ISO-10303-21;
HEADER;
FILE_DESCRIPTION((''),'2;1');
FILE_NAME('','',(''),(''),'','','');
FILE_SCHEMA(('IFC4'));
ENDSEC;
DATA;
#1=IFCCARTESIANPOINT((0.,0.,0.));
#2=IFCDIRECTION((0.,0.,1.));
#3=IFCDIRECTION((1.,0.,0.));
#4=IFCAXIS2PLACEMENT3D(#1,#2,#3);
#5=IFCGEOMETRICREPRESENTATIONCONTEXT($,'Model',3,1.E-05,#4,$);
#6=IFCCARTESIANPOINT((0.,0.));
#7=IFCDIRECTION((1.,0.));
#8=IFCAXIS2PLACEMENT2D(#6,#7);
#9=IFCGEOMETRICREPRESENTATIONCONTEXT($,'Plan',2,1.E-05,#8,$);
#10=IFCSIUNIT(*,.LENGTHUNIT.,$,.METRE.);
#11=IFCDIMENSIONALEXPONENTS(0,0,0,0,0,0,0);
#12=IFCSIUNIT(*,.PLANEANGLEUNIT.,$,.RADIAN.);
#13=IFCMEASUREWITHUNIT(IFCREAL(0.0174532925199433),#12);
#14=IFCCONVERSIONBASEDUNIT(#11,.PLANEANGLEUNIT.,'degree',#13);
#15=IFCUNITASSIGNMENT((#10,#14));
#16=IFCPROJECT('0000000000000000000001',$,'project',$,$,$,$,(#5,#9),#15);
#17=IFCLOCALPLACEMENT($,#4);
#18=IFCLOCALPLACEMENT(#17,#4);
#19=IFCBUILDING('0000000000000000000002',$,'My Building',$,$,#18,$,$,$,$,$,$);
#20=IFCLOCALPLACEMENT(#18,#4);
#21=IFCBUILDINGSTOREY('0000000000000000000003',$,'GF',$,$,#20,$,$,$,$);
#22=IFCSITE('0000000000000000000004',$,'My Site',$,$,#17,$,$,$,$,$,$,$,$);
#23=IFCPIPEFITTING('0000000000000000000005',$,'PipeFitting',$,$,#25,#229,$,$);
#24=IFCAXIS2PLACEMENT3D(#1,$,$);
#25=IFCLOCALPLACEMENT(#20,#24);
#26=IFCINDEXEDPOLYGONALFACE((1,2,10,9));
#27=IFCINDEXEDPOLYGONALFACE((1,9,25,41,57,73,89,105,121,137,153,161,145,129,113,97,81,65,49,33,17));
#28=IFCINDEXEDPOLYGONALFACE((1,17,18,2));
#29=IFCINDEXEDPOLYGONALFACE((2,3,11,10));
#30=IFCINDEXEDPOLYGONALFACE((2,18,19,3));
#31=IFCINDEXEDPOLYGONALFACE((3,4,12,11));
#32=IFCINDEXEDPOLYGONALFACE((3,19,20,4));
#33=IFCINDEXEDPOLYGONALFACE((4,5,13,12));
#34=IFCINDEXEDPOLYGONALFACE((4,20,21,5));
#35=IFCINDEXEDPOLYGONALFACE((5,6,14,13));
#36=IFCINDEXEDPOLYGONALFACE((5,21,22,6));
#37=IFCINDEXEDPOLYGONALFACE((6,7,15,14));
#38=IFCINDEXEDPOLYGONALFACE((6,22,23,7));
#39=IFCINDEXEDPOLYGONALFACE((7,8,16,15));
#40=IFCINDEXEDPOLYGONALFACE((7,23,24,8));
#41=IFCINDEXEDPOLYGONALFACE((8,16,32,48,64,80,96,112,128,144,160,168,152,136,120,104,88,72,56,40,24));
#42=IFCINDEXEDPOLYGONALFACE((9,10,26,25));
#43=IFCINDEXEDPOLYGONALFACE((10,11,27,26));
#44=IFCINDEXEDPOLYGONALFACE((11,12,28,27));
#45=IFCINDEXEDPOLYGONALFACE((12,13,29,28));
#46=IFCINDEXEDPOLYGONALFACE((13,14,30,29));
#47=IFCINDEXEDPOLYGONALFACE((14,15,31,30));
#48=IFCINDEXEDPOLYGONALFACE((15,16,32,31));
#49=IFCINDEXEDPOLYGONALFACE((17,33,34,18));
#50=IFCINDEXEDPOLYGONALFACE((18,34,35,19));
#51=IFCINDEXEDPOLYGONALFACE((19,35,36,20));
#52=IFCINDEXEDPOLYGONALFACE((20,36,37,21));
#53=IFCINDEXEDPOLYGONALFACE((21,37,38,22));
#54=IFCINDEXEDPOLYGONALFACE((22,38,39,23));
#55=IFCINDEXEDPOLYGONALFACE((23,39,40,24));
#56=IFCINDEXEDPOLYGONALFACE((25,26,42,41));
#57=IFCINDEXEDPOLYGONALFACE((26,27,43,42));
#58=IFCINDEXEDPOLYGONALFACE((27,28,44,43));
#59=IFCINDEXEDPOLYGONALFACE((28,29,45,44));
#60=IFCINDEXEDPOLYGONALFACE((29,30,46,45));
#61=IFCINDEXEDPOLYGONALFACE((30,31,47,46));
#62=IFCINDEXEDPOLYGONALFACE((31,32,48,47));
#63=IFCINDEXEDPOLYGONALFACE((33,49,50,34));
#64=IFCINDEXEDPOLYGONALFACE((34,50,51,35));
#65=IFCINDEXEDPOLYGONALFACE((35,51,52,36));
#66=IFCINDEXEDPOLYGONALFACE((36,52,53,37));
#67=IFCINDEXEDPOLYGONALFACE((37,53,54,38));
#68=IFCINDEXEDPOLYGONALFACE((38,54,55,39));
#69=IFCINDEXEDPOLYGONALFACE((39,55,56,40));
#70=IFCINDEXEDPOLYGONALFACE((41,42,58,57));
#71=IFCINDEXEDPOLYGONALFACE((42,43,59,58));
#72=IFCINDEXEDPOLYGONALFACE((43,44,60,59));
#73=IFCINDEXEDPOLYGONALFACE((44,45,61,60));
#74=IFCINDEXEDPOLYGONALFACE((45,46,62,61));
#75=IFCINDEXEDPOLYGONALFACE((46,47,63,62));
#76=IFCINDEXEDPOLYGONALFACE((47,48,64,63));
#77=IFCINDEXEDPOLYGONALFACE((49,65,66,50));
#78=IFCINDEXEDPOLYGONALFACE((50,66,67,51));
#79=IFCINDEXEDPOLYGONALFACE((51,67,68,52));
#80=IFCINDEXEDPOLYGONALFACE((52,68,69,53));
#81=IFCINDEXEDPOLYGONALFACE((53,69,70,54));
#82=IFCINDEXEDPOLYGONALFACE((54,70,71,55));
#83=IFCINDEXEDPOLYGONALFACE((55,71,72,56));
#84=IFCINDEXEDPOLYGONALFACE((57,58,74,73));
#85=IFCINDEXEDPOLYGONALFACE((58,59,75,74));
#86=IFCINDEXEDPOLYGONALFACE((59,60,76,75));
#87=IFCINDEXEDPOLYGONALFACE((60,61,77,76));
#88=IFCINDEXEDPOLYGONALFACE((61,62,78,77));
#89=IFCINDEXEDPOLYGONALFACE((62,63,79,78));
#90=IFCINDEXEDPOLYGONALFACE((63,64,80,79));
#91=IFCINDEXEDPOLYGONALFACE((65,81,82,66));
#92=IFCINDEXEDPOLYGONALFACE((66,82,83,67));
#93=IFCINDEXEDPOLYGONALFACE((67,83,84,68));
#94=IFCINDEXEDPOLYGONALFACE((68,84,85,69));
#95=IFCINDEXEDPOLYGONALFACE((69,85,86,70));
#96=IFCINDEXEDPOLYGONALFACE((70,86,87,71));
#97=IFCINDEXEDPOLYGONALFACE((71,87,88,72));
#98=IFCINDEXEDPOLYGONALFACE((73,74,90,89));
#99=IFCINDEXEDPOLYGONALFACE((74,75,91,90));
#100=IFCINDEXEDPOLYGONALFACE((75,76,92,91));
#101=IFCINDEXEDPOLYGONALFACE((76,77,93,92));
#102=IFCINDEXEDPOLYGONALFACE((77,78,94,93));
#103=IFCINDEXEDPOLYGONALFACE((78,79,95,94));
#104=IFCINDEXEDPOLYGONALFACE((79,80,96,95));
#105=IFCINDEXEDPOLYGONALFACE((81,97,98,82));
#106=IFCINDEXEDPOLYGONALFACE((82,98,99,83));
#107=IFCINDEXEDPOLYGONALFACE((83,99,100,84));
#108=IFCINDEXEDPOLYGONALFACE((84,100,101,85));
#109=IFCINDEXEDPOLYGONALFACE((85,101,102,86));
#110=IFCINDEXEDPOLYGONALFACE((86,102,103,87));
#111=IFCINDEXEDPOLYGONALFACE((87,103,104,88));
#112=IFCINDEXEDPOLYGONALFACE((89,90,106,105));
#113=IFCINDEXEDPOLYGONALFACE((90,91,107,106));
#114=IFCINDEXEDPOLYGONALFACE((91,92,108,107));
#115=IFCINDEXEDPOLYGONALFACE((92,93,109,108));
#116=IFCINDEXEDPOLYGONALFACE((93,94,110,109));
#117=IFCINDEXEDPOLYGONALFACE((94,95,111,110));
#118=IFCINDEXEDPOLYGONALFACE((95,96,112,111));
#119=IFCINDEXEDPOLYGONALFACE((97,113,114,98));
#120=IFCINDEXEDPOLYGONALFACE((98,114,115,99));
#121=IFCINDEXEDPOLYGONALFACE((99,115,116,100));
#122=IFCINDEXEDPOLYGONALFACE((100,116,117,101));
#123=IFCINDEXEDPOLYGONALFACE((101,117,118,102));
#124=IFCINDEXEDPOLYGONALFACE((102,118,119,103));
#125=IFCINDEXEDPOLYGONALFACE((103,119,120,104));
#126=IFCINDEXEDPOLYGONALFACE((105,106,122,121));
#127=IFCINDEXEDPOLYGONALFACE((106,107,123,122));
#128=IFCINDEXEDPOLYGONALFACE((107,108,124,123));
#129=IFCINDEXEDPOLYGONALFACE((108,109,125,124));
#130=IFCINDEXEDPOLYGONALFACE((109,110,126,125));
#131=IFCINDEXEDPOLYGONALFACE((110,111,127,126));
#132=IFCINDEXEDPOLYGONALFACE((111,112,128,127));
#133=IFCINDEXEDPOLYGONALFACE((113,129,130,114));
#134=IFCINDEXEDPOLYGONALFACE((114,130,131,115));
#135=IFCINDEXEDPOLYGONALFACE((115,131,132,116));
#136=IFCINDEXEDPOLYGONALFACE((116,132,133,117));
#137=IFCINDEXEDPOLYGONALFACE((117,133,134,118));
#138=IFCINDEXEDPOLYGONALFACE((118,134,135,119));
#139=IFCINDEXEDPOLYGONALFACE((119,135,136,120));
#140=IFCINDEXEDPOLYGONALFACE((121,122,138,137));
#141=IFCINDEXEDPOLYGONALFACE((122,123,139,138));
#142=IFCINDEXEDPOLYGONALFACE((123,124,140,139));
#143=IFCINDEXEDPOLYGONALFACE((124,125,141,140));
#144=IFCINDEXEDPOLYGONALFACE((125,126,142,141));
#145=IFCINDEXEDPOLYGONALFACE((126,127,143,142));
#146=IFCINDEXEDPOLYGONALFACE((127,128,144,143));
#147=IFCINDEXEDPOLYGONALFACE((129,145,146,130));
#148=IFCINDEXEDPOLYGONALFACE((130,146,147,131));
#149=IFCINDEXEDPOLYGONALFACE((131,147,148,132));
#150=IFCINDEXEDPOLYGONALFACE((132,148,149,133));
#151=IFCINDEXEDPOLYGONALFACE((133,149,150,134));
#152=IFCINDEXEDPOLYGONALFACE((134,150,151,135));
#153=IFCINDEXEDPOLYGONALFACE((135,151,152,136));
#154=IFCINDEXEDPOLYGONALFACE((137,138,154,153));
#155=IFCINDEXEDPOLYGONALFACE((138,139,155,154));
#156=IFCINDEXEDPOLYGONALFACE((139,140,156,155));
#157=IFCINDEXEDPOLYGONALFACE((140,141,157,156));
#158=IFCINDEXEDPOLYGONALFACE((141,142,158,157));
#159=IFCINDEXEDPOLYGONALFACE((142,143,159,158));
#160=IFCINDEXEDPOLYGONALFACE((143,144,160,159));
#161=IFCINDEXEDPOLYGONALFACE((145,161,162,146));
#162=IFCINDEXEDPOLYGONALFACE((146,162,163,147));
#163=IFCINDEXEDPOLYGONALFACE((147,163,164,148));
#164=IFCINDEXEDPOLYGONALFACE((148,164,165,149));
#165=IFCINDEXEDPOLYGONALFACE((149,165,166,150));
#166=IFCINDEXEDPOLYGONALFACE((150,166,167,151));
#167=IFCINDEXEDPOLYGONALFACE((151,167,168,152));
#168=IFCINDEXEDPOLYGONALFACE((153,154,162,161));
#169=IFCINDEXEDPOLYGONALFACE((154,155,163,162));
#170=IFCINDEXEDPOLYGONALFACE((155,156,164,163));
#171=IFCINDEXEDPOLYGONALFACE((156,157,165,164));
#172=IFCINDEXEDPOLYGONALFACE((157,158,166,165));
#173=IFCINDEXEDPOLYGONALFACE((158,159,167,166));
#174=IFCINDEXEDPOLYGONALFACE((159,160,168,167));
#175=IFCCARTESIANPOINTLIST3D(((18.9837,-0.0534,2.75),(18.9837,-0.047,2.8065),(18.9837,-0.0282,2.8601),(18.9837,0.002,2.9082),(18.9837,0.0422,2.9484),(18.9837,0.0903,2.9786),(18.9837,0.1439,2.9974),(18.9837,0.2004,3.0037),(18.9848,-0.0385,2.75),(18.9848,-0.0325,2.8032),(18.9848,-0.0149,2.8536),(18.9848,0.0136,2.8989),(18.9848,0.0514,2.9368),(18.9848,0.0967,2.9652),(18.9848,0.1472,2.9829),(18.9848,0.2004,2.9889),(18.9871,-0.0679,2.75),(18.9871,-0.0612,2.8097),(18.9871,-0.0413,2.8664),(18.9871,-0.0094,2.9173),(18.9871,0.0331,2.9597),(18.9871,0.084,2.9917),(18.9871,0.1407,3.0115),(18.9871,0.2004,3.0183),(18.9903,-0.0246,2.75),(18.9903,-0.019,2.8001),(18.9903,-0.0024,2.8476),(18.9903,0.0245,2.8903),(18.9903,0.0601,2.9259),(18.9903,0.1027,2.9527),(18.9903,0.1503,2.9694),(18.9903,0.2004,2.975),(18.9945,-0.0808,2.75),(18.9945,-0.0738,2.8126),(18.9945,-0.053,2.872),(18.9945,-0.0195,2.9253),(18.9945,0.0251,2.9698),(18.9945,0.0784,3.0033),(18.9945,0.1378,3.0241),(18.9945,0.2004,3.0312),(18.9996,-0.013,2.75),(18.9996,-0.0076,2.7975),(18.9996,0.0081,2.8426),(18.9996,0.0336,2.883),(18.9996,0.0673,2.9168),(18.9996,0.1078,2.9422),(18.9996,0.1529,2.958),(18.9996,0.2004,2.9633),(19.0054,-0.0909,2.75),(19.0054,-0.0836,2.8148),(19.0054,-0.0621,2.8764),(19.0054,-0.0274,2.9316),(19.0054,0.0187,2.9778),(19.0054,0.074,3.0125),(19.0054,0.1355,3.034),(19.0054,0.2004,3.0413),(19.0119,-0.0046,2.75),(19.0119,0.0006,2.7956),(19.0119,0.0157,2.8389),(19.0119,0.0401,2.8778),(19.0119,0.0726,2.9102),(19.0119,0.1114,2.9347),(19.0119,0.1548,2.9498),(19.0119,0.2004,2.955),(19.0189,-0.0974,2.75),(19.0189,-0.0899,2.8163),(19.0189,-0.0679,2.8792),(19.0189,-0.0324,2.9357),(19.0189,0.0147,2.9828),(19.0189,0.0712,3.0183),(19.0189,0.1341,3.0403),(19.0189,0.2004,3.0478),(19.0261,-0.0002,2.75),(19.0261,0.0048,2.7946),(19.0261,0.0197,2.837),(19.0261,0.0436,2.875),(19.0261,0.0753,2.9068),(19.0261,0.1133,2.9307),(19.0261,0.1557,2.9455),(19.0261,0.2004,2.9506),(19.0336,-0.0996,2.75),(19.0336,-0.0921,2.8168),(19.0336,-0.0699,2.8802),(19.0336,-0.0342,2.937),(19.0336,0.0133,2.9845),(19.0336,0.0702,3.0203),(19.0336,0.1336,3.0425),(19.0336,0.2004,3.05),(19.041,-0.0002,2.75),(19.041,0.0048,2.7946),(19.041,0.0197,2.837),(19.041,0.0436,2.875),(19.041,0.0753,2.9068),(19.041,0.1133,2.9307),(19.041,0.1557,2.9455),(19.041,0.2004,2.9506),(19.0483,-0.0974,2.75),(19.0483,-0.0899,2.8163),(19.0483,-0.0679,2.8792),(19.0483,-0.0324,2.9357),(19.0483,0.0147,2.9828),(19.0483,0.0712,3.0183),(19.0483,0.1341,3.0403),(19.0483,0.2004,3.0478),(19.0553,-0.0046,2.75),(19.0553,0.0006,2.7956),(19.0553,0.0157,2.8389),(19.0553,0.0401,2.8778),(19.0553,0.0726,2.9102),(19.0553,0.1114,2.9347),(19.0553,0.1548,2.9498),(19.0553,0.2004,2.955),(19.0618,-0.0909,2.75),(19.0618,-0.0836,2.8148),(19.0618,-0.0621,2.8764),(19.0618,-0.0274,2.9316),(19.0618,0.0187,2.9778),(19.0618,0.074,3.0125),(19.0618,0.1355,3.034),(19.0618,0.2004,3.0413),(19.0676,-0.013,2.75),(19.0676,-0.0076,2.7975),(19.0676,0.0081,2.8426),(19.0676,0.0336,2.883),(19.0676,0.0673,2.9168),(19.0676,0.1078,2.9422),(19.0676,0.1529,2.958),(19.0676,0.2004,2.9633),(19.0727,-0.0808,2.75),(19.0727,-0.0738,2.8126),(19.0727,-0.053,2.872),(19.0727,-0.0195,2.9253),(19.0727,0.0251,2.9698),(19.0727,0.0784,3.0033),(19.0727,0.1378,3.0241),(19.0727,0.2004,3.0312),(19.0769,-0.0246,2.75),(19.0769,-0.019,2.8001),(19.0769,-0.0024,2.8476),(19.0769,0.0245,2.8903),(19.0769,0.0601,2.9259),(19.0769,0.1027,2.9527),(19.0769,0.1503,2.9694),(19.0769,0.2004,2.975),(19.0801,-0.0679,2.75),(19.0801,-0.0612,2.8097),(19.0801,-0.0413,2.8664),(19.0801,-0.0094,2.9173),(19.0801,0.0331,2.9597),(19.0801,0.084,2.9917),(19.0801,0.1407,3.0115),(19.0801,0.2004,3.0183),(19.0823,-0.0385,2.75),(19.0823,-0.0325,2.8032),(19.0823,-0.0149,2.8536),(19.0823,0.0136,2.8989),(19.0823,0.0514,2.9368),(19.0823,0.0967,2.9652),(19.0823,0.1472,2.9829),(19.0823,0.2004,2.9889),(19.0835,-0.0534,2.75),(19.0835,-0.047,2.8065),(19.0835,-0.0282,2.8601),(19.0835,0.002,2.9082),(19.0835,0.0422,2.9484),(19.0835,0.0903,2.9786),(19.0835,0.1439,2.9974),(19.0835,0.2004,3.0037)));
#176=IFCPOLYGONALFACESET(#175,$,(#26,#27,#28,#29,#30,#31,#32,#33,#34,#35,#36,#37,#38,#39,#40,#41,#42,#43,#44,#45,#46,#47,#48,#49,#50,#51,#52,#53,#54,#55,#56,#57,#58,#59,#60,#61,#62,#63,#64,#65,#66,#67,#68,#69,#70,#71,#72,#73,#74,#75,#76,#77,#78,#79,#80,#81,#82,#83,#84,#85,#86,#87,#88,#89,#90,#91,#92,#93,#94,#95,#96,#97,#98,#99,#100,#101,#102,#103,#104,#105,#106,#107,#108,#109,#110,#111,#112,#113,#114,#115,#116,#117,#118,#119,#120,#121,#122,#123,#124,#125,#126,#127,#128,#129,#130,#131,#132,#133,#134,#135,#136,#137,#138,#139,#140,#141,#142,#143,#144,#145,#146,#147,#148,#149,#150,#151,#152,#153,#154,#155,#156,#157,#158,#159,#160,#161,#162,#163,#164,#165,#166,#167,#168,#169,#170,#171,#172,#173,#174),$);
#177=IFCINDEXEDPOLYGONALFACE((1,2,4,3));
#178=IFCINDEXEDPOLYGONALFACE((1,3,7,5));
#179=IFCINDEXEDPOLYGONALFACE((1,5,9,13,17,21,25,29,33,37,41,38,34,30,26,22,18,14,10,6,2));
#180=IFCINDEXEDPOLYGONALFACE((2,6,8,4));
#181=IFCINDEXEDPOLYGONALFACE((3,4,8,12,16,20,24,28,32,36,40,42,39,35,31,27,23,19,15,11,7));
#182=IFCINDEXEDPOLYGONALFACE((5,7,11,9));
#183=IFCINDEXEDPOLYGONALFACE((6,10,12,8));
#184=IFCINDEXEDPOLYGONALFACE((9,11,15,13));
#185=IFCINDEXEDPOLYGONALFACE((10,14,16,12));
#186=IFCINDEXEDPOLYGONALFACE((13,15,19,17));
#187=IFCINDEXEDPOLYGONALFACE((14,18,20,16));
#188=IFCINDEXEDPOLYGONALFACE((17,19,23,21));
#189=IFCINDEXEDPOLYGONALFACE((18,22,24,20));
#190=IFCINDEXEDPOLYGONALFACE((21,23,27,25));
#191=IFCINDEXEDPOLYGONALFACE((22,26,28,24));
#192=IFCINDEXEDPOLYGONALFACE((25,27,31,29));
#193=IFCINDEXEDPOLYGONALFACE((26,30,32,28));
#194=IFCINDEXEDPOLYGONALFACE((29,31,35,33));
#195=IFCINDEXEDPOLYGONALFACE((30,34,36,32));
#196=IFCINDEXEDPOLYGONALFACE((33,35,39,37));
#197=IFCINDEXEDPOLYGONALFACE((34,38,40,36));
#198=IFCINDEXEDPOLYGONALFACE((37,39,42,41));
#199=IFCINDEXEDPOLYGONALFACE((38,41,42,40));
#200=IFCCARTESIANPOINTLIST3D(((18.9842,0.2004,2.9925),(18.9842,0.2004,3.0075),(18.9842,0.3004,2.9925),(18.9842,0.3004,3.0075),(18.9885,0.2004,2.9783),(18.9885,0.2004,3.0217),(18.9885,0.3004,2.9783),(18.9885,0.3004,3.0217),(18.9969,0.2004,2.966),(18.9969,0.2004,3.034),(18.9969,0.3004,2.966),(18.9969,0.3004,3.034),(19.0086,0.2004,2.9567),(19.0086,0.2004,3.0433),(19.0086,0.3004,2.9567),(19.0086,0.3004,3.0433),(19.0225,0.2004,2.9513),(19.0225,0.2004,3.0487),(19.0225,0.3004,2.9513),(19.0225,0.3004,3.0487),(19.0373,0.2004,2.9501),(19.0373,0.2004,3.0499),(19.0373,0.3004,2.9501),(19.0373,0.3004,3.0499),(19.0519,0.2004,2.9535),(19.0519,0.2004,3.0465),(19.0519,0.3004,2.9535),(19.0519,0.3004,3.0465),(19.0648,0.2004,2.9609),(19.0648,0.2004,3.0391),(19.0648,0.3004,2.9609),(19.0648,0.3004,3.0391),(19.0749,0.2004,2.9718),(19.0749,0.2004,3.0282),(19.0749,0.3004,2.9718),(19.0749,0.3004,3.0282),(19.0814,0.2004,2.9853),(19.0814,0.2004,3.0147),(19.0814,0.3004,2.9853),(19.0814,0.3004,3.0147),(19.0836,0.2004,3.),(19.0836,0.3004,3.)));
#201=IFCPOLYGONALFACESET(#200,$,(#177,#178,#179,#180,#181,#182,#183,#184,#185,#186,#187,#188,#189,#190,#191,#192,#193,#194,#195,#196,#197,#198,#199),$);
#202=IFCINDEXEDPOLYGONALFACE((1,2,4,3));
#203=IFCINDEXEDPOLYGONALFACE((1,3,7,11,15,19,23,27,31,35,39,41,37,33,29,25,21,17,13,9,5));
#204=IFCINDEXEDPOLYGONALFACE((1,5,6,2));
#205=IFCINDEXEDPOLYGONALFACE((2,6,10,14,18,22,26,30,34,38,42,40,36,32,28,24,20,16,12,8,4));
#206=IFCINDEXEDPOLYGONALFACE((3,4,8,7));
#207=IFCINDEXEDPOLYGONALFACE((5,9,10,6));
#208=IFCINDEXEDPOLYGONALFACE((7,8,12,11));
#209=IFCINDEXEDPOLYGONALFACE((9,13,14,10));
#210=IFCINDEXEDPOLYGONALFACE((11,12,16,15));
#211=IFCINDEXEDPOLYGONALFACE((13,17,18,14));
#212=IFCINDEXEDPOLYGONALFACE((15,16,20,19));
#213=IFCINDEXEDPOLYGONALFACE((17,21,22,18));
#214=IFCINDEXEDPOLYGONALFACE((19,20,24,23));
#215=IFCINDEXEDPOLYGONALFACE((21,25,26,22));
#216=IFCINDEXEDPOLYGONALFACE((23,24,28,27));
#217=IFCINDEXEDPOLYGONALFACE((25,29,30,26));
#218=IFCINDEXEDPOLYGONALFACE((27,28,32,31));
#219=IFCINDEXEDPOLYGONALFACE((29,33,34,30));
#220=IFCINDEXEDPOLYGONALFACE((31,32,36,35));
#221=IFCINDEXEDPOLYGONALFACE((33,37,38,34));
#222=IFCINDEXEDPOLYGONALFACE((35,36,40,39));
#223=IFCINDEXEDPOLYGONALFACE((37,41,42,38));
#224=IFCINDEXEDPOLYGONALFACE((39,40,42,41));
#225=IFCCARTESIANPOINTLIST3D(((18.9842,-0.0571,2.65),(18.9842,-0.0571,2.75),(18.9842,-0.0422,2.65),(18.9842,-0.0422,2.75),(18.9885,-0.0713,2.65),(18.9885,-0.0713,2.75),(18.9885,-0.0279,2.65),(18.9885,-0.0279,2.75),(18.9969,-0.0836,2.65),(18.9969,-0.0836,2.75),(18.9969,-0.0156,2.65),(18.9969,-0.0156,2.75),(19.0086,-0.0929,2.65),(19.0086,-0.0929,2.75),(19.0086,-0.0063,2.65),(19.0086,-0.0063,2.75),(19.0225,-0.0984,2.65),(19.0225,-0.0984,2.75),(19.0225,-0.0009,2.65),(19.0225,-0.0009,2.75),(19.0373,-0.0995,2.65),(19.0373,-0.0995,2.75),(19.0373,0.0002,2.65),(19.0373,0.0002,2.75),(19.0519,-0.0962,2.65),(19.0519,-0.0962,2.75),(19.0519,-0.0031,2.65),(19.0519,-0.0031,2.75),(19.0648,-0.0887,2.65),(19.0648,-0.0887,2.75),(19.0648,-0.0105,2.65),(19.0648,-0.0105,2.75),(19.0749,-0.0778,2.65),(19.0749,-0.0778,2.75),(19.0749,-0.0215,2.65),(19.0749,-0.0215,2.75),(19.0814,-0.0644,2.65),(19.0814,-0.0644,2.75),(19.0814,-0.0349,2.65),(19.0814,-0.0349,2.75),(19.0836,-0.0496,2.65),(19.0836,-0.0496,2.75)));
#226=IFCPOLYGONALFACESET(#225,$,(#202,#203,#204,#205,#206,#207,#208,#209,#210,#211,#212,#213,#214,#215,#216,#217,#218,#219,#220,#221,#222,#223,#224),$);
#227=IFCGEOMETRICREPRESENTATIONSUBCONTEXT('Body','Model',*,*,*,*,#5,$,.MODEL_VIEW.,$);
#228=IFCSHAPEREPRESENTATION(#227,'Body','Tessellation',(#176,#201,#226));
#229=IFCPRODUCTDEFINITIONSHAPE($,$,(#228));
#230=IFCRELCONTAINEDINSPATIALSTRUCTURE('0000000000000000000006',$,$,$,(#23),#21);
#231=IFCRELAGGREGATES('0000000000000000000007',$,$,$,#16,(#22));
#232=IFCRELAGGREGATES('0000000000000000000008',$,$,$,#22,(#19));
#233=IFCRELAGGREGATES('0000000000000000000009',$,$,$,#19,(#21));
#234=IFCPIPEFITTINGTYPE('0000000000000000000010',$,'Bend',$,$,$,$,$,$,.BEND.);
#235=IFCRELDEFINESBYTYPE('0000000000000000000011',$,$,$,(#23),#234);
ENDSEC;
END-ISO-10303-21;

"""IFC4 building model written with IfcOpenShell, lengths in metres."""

from ifc_helpers import new_model, entity, si_unit, converted_unit, frame, origin_with_axes, origin_2d_with_axis, place, context, subcontext, project, spatial, circle, extrude, source, transform, mapped, type_object, type_shapes, element, save


model = new_model("IFC4")

# Units and contexts
model_context = context("Model", 3, precision=1e-05, world=origin_with_axes())
plan_context = context("Plan", 2, precision=1e-05, world=origin_2d_with_axis())
body_context_1 = subcontext(model_context, "Body", "Model", "MODEL_VIEW")
ifc_project = project(units=[si_unit("LENGTHUNIT", "METRE"), converted_unit("PLANEANGLEUNIT", "degree", entity("IfcReal", 0.0174532925199433), si_unit("PLANEANGLEUNIT", "RADIAN"), dimensions=[0, 0, 0, 0, 0, 0, 0])], contexts=[model_context, plan_context])

# Site, building, storey
site_placement = place(None, origin_with_axes())
site = spatial("IfcSite", under=ifc_project, at=site_placement, Name="My Site")
building_placement = place(site_placement, origin_with_axes())
building = spatial("IfcBuilding", under=site, at=building_placement, Name="My Building")
storey_placement = place(building_placement, origin_with_axes())
storey = spatial("IfcBuildingStorey", under=building, at=storey_placement, Name="GF")

# Pipe fitting
pipe_fitting_type = type_object("IfcPipeFittingType", Name="Bend", PredefinedType="BEND")
shared_shape_1 = source(origin_with_axes(), body_context_1, "Body", "SolidModel", [
    entity("IfcSweptDiskSolid", entity("IfcIndexedPolyCurve", entity("IfcCartesianPointList3D", [[0.0, 0.0, 0.1], [0.0, -0.0732, 0.2768], [0.0, -0.25, 0.35]]), [entity("IfcArcIndex", [1, 2, 3])]), 0.05),
    extrude(circle(Radius=0.05), origin_with_axes(), (0.0, 0.0, 1.0), 0.1),
    extrude(circle(Radius=0.05), frame((0.0, -0.25, 0.35), z_axis=(0.0, -1.0, 0.0), x_axis=(1.0, 0.0, 0.0)), (0.0, 0.0, 1.0), 0.1),
])
type_shapes(pipe_fitting_type, [shared_shape_1])
for number, where, z_axis, x_axis, name in (
    (1, (19.0336, 0.3004, 3.0), (0.0, -1.0, 0.0), (1.0, 0.0, 0.0), "PipeFitting"),
):
    element("IfcPipeFitting", number, at=place(storey_placement, frame(where, z_axis=z_axis, x_axis=x_axis)), inside=storey, type_object=pipe_fitting_type, Name=name, context=body_context_1, shape_type="MappedRepresentation", body=[
        mapped(shared_shape_1, transform((0.0, 0.0, 0.0), x_axis=(1.0, 0.0, 0.0), y_axis=(0.0, 1.0, 0.0), z_axis=(0.0, 0.0, 1.0), scale=1.0)),
    ])

save(model, "model.ifc")
